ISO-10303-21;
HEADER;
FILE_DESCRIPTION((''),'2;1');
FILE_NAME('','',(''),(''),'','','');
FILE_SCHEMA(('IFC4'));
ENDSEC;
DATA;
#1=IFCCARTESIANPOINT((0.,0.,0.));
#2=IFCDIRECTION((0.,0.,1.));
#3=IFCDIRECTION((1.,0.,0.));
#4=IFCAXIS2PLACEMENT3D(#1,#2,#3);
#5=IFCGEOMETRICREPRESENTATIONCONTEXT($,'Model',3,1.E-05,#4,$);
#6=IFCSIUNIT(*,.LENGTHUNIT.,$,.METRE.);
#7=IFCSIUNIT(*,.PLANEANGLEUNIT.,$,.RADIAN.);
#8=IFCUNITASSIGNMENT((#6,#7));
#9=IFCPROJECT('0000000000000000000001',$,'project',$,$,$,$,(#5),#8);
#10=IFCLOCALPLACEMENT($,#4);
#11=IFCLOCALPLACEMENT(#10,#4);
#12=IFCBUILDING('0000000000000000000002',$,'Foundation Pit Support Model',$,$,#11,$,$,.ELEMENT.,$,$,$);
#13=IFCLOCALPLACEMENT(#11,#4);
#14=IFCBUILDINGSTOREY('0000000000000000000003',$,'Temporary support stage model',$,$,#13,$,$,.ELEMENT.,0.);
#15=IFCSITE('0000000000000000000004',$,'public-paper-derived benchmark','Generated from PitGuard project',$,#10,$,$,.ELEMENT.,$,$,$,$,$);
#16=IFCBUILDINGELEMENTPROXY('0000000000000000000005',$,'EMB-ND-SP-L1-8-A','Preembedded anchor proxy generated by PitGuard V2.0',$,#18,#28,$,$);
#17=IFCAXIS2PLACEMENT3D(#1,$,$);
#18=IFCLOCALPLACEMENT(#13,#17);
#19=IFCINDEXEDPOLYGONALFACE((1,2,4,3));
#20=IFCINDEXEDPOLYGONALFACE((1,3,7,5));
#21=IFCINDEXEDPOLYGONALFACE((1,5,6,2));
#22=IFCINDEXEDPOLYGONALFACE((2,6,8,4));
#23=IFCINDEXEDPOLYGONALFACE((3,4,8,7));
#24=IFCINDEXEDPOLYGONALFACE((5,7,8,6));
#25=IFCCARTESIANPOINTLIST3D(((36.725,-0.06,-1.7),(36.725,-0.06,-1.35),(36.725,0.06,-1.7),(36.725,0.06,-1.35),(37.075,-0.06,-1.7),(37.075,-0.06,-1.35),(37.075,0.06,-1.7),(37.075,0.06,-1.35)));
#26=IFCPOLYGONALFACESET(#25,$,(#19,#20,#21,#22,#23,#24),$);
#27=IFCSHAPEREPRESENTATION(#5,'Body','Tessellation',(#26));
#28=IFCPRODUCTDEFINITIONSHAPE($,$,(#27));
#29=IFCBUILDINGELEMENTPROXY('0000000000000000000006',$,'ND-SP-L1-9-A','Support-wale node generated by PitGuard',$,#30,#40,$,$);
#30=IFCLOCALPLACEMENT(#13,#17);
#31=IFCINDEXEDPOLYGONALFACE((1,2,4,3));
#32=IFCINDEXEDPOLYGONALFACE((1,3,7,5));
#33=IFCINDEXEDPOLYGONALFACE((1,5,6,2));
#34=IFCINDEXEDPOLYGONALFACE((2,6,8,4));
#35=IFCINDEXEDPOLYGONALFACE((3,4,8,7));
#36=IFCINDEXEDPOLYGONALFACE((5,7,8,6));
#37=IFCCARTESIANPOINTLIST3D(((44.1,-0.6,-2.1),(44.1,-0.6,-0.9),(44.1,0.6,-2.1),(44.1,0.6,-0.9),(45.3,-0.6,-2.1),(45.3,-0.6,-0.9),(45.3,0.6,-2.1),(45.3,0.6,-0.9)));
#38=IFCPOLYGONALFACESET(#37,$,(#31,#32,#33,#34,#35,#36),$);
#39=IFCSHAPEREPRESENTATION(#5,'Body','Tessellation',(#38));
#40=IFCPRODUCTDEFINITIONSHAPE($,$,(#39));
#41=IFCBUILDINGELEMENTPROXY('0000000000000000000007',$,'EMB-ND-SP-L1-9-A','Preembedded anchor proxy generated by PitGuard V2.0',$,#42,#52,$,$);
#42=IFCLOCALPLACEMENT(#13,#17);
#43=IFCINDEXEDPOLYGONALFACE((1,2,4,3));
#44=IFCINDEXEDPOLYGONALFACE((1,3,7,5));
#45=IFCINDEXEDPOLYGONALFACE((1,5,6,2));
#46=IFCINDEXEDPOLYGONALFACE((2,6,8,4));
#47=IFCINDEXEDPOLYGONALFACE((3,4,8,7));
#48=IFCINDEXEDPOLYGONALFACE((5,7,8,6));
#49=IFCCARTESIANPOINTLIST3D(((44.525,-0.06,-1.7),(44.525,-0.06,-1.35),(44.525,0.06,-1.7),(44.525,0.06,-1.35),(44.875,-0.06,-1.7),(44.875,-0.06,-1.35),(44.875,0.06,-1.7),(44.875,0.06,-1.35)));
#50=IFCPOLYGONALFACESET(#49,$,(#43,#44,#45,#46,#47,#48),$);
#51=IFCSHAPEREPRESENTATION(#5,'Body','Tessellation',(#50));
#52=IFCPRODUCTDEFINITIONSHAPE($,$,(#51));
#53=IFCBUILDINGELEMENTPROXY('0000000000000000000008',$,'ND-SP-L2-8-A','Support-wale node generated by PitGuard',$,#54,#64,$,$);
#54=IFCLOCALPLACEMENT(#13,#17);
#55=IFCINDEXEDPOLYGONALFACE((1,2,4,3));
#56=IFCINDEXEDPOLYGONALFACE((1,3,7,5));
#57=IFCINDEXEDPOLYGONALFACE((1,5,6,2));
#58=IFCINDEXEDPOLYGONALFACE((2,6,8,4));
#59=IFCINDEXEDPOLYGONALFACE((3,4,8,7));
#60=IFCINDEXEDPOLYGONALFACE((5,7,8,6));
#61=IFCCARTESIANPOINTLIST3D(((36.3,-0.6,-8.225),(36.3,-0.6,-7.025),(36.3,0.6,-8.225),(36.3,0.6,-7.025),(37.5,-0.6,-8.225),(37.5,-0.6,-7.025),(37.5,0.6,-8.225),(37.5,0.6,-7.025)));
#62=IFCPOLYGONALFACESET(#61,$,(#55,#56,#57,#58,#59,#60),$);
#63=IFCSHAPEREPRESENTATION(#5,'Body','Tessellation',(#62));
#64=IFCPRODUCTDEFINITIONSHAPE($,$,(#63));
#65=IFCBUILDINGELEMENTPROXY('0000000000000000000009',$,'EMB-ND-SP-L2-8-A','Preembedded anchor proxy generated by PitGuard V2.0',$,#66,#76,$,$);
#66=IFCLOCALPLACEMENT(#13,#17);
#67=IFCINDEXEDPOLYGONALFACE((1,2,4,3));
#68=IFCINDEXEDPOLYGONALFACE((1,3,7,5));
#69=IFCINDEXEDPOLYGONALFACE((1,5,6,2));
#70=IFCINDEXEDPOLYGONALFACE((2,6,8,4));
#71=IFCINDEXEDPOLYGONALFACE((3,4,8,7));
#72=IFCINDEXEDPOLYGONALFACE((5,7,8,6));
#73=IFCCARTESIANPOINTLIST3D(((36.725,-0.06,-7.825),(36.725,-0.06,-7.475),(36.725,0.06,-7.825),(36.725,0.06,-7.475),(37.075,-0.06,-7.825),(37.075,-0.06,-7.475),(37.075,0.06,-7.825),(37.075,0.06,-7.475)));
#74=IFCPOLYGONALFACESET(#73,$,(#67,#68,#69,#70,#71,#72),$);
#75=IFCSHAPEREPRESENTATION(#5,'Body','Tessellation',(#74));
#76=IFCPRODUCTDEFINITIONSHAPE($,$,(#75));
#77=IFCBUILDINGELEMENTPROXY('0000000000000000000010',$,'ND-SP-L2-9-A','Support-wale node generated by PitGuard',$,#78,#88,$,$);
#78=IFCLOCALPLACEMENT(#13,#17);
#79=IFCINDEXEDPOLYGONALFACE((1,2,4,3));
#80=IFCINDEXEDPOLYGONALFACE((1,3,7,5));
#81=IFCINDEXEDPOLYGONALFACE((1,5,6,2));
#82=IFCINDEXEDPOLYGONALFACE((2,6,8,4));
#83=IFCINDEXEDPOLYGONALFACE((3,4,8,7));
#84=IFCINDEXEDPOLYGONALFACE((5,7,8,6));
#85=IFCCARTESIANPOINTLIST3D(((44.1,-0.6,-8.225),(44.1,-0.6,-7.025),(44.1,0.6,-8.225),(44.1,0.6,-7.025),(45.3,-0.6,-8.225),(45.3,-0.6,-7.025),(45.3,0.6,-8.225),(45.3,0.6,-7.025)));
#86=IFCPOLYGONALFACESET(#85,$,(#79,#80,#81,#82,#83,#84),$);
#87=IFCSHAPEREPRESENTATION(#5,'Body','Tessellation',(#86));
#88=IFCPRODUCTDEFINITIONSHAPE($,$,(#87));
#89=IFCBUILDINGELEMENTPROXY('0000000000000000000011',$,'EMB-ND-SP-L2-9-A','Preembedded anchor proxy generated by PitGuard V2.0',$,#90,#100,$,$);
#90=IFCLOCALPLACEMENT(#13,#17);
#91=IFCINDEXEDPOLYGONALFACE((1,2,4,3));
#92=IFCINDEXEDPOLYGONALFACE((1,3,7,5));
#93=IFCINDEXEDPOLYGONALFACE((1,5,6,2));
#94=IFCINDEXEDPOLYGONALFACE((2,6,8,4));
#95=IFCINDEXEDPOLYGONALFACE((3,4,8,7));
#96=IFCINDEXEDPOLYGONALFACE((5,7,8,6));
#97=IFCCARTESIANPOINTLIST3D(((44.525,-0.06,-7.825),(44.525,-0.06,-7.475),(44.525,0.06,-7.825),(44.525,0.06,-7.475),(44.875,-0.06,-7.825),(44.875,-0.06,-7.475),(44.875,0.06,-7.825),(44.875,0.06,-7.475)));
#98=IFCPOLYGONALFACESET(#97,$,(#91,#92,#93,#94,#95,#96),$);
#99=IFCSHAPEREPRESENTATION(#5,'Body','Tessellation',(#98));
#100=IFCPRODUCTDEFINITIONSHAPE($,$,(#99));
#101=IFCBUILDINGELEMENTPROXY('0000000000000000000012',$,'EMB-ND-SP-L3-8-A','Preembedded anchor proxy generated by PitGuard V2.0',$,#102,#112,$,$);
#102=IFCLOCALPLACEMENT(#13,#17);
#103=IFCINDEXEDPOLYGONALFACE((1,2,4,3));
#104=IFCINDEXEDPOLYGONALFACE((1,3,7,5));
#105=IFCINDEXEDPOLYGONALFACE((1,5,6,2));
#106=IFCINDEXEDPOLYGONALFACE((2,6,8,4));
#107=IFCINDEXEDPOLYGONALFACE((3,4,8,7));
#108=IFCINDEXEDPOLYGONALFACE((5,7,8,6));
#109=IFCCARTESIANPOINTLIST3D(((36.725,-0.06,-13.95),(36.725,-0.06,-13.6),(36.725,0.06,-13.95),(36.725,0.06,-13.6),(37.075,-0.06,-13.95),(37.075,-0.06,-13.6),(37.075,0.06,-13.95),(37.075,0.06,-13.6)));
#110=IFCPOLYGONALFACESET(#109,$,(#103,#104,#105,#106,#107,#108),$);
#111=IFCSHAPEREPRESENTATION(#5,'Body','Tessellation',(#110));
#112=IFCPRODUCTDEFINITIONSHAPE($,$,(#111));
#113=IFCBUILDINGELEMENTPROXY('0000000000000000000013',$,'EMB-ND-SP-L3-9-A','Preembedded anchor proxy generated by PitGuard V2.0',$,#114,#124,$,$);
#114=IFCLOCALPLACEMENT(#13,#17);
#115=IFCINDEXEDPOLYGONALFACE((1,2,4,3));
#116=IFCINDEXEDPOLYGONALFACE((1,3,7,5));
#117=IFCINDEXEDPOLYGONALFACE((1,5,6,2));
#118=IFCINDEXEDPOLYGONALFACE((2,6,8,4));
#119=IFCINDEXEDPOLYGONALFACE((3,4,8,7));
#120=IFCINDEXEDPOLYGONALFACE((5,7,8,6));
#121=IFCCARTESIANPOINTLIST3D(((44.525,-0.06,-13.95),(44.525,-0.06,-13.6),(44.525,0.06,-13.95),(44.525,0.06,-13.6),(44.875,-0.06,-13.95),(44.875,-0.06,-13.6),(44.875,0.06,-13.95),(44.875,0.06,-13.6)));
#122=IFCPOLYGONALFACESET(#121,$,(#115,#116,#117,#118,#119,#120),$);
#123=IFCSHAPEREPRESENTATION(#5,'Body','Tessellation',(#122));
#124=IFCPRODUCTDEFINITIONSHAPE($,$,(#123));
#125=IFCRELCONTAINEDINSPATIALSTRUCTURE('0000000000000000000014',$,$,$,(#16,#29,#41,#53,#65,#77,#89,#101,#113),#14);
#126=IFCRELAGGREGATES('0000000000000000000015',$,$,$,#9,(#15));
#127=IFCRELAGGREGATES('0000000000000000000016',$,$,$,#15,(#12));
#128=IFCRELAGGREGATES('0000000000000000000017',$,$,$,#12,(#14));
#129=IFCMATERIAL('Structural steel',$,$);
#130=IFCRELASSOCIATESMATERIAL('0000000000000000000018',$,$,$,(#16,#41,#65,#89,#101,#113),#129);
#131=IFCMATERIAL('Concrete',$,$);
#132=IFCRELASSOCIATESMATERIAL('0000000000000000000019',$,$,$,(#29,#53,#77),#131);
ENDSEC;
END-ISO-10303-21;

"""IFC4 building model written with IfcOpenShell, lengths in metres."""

from ifc_helpers import new_model, si_unit, frame, origin_with_axes, origin_2d, place, context, project, spatial, rectangle, extrude, material, element, save


model = new_model("IFC4")

# Units and contexts
model_context = context("Model", 3, precision=1e-05, world=origin_with_axes())
ifc_project = project(units=[si_unit("LENGTHUNIT", "METRE"), si_unit("PLANEANGLEUNIT", "RADIAN")], contexts=[model_context])

# Site, building, storey
site_placement = place(None, origin_with_axes())
site = spatial("IfcSite", under=ifc_project, at=site_placement, Name="public-paper-derived benchmark", Description="Generated from PitGuard project", CompositionType="ELEMENT")
building_placement = place(site_placement, origin_with_axes())
building = spatial("IfcBuilding", under=site, at=building_placement, Name="Foundation Pit Support Model", CompositionType="ELEMENT")
storey_placement = place(building_placement, origin_with_axes())
storey = spatial("IfcBuildingStorey", under=building, at=storey_placement, Name="Temporary support stage model", CompositionType="ELEMENT", Elevation=0.0)

# Shared definitions
ifc_material_1 = material(Name="Concrete")

# Shared definitions
ifc_material_2 = material(Name="Structural steel")

# Building element proxies
proxy_1_placement = place(storey_placement, frame((36.9, 0.0, -1.7), z_axis=(0.0, 0.0, 1.0), x_axis=(1.0, 0.0, 0.0)))
element("IfcBuildingElementProxy", 1, at=proxy_1_placement, inside=storey, material=ifc_material_2, Name="EMB-ND-SP-L1-8-A", Description="Preembedded anchor proxy generated by PitGuard V2.0", context=model_context, shape_type="SweptSolid", body=[
    extrude(rectangle(XDim=0.35, YDim=0.12, at=origin_2d()), origin_with_axes(), (0.0, 0.0, 1.0), 0.35),
])
proxy_2_placement = place(storey_placement, frame((44.7, 0.0, -2.1), z_axis=(0.0, 0.0, 1.0), x_axis=(1.0, 0.0, 0.0)))
element("IfcBuildingElementProxy", 2, at=proxy_2_placement, inside=storey, material=ifc_material_1, Name="ND-SP-L1-9-A", Description="Support-wale node generated by PitGuard", context=model_context, shape_type="SweptSolid", body=[
    extrude(rectangle(XDim=1.2, YDim=1.2, at=origin_2d()), origin_with_axes(), (0.0, 0.0, 1.0), 1.2),
])
proxy_3_placement = place(storey_placement, frame((44.7, 0.0, -1.7), z_axis=(0.0, 0.0, 1.0), x_axis=(1.0, 0.0, 0.0)))
element("IfcBuildingElementProxy", 3, at=proxy_3_placement, inside=storey, material=ifc_material_2, Name="EMB-ND-SP-L1-9-A", Description="Preembedded anchor proxy generated by PitGuard V2.0", context=model_context, shape_type="SweptSolid", body=[
    extrude(rectangle(XDim=0.35, YDim=0.12, at=origin_2d()), origin_with_axes(), (0.0, 0.0, 1.0), 0.35),
])
proxy_4_placement = place(storey_placement, frame((36.9, 0.0, -8.225), z_axis=(0.0, 0.0, 1.0), x_axis=(1.0, 0.0, 0.0)))
element("IfcBuildingElementProxy", 4, at=proxy_4_placement, inside=storey, material=ifc_material_1, Name="ND-SP-L2-8-A", Description="Support-wale node generated by PitGuard", context=model_context, shape_type="SweptSolid", body=[
    extrude(rectangle(XDim=1.2, YDim=1.2, at=origin_2d()), origin_with_axes(), (0.0, 0.0, 1.0), 1.2),
])
proxy_5_placement = place(storey_placement, frame((36.9, 0.0, -7.825), z_axis=(0.0, 0.0, 1.0), x_axis=(1.0, 0.0, 0.0)))
element("IfcBuildingElementProxy", 5, at=proxy_5_placement, inside=storey, material=ifc_material_2, Name="EMB-ND-SP-L2-8-A", Description="Preembedded anchor proxy generated by PitGuard V2.0", context=model_context, shape_type="SweptSolid", body=[
    extrude(rectangle(XDim=0.35, YDim=0.12, at=origin_2d()), origin_with_axes(), (0.0, 0.0, 1.0), 0.35),
])
proxy_6_placement = place(storey_placement, frame((44.7, 0.0, -8.225), z_axis=(0.0, 0.0, 1.0), x_axis=(1.0, 0.0, 0.0)))
element("IfcBuildingElementProxy", 6, at=proxy_6_placement, inside=storey, material=ifc_material_1, Name="ND-SP-L2-9-A", Description="Support-wale node generated by PitGuard", context=model_context, shape_type="SweptSolid", body=[
    extrude(rectangle(XDim=1.2, YDim=1.2, at=origin_2d()), origin_with_axes(), (0.0, 0.0, 1.0), 1.2),
])
for number, where, z_axis, x_axis, name in (
    (7, (44.7, 0.0, -7.825), (0.0, 0.0, 1.0), (1.0, 0.0, 0.0), "EMB-ND-SP-L2-9-A"),
    (8, (36.9, 0.0, -13.95), (0.0, 0.0, 1.0), (1.0, 0.0, 0.0), "EMB-ND-SP-L3-8-A"),
    (9, (44.7, 0.0, -13.95), (0.0, 0.0, 1.0), (1.0, 0.0, 0.0), "EMB-ND-SP-L3-9-A"),
):
    element("IfcBuildingElementProxy", number, at=place(storey_placement, frame(where, z_axis=z_axis, x_axis=x_axis)), inside=storey, material=ifc_material_2, Name=name, Description="Preembedded anchor proxy generated by PitGuard V2.0", context=model_context, shape_type="SweptSolid", body=[
        extrude(rectangle(XDim=0.35, YDim=0.12, at=origin_2d()), origin_with_axes(), (0.0, 0.0, 1.0), 0.35),
    ])

save(model, "model.ifc")
